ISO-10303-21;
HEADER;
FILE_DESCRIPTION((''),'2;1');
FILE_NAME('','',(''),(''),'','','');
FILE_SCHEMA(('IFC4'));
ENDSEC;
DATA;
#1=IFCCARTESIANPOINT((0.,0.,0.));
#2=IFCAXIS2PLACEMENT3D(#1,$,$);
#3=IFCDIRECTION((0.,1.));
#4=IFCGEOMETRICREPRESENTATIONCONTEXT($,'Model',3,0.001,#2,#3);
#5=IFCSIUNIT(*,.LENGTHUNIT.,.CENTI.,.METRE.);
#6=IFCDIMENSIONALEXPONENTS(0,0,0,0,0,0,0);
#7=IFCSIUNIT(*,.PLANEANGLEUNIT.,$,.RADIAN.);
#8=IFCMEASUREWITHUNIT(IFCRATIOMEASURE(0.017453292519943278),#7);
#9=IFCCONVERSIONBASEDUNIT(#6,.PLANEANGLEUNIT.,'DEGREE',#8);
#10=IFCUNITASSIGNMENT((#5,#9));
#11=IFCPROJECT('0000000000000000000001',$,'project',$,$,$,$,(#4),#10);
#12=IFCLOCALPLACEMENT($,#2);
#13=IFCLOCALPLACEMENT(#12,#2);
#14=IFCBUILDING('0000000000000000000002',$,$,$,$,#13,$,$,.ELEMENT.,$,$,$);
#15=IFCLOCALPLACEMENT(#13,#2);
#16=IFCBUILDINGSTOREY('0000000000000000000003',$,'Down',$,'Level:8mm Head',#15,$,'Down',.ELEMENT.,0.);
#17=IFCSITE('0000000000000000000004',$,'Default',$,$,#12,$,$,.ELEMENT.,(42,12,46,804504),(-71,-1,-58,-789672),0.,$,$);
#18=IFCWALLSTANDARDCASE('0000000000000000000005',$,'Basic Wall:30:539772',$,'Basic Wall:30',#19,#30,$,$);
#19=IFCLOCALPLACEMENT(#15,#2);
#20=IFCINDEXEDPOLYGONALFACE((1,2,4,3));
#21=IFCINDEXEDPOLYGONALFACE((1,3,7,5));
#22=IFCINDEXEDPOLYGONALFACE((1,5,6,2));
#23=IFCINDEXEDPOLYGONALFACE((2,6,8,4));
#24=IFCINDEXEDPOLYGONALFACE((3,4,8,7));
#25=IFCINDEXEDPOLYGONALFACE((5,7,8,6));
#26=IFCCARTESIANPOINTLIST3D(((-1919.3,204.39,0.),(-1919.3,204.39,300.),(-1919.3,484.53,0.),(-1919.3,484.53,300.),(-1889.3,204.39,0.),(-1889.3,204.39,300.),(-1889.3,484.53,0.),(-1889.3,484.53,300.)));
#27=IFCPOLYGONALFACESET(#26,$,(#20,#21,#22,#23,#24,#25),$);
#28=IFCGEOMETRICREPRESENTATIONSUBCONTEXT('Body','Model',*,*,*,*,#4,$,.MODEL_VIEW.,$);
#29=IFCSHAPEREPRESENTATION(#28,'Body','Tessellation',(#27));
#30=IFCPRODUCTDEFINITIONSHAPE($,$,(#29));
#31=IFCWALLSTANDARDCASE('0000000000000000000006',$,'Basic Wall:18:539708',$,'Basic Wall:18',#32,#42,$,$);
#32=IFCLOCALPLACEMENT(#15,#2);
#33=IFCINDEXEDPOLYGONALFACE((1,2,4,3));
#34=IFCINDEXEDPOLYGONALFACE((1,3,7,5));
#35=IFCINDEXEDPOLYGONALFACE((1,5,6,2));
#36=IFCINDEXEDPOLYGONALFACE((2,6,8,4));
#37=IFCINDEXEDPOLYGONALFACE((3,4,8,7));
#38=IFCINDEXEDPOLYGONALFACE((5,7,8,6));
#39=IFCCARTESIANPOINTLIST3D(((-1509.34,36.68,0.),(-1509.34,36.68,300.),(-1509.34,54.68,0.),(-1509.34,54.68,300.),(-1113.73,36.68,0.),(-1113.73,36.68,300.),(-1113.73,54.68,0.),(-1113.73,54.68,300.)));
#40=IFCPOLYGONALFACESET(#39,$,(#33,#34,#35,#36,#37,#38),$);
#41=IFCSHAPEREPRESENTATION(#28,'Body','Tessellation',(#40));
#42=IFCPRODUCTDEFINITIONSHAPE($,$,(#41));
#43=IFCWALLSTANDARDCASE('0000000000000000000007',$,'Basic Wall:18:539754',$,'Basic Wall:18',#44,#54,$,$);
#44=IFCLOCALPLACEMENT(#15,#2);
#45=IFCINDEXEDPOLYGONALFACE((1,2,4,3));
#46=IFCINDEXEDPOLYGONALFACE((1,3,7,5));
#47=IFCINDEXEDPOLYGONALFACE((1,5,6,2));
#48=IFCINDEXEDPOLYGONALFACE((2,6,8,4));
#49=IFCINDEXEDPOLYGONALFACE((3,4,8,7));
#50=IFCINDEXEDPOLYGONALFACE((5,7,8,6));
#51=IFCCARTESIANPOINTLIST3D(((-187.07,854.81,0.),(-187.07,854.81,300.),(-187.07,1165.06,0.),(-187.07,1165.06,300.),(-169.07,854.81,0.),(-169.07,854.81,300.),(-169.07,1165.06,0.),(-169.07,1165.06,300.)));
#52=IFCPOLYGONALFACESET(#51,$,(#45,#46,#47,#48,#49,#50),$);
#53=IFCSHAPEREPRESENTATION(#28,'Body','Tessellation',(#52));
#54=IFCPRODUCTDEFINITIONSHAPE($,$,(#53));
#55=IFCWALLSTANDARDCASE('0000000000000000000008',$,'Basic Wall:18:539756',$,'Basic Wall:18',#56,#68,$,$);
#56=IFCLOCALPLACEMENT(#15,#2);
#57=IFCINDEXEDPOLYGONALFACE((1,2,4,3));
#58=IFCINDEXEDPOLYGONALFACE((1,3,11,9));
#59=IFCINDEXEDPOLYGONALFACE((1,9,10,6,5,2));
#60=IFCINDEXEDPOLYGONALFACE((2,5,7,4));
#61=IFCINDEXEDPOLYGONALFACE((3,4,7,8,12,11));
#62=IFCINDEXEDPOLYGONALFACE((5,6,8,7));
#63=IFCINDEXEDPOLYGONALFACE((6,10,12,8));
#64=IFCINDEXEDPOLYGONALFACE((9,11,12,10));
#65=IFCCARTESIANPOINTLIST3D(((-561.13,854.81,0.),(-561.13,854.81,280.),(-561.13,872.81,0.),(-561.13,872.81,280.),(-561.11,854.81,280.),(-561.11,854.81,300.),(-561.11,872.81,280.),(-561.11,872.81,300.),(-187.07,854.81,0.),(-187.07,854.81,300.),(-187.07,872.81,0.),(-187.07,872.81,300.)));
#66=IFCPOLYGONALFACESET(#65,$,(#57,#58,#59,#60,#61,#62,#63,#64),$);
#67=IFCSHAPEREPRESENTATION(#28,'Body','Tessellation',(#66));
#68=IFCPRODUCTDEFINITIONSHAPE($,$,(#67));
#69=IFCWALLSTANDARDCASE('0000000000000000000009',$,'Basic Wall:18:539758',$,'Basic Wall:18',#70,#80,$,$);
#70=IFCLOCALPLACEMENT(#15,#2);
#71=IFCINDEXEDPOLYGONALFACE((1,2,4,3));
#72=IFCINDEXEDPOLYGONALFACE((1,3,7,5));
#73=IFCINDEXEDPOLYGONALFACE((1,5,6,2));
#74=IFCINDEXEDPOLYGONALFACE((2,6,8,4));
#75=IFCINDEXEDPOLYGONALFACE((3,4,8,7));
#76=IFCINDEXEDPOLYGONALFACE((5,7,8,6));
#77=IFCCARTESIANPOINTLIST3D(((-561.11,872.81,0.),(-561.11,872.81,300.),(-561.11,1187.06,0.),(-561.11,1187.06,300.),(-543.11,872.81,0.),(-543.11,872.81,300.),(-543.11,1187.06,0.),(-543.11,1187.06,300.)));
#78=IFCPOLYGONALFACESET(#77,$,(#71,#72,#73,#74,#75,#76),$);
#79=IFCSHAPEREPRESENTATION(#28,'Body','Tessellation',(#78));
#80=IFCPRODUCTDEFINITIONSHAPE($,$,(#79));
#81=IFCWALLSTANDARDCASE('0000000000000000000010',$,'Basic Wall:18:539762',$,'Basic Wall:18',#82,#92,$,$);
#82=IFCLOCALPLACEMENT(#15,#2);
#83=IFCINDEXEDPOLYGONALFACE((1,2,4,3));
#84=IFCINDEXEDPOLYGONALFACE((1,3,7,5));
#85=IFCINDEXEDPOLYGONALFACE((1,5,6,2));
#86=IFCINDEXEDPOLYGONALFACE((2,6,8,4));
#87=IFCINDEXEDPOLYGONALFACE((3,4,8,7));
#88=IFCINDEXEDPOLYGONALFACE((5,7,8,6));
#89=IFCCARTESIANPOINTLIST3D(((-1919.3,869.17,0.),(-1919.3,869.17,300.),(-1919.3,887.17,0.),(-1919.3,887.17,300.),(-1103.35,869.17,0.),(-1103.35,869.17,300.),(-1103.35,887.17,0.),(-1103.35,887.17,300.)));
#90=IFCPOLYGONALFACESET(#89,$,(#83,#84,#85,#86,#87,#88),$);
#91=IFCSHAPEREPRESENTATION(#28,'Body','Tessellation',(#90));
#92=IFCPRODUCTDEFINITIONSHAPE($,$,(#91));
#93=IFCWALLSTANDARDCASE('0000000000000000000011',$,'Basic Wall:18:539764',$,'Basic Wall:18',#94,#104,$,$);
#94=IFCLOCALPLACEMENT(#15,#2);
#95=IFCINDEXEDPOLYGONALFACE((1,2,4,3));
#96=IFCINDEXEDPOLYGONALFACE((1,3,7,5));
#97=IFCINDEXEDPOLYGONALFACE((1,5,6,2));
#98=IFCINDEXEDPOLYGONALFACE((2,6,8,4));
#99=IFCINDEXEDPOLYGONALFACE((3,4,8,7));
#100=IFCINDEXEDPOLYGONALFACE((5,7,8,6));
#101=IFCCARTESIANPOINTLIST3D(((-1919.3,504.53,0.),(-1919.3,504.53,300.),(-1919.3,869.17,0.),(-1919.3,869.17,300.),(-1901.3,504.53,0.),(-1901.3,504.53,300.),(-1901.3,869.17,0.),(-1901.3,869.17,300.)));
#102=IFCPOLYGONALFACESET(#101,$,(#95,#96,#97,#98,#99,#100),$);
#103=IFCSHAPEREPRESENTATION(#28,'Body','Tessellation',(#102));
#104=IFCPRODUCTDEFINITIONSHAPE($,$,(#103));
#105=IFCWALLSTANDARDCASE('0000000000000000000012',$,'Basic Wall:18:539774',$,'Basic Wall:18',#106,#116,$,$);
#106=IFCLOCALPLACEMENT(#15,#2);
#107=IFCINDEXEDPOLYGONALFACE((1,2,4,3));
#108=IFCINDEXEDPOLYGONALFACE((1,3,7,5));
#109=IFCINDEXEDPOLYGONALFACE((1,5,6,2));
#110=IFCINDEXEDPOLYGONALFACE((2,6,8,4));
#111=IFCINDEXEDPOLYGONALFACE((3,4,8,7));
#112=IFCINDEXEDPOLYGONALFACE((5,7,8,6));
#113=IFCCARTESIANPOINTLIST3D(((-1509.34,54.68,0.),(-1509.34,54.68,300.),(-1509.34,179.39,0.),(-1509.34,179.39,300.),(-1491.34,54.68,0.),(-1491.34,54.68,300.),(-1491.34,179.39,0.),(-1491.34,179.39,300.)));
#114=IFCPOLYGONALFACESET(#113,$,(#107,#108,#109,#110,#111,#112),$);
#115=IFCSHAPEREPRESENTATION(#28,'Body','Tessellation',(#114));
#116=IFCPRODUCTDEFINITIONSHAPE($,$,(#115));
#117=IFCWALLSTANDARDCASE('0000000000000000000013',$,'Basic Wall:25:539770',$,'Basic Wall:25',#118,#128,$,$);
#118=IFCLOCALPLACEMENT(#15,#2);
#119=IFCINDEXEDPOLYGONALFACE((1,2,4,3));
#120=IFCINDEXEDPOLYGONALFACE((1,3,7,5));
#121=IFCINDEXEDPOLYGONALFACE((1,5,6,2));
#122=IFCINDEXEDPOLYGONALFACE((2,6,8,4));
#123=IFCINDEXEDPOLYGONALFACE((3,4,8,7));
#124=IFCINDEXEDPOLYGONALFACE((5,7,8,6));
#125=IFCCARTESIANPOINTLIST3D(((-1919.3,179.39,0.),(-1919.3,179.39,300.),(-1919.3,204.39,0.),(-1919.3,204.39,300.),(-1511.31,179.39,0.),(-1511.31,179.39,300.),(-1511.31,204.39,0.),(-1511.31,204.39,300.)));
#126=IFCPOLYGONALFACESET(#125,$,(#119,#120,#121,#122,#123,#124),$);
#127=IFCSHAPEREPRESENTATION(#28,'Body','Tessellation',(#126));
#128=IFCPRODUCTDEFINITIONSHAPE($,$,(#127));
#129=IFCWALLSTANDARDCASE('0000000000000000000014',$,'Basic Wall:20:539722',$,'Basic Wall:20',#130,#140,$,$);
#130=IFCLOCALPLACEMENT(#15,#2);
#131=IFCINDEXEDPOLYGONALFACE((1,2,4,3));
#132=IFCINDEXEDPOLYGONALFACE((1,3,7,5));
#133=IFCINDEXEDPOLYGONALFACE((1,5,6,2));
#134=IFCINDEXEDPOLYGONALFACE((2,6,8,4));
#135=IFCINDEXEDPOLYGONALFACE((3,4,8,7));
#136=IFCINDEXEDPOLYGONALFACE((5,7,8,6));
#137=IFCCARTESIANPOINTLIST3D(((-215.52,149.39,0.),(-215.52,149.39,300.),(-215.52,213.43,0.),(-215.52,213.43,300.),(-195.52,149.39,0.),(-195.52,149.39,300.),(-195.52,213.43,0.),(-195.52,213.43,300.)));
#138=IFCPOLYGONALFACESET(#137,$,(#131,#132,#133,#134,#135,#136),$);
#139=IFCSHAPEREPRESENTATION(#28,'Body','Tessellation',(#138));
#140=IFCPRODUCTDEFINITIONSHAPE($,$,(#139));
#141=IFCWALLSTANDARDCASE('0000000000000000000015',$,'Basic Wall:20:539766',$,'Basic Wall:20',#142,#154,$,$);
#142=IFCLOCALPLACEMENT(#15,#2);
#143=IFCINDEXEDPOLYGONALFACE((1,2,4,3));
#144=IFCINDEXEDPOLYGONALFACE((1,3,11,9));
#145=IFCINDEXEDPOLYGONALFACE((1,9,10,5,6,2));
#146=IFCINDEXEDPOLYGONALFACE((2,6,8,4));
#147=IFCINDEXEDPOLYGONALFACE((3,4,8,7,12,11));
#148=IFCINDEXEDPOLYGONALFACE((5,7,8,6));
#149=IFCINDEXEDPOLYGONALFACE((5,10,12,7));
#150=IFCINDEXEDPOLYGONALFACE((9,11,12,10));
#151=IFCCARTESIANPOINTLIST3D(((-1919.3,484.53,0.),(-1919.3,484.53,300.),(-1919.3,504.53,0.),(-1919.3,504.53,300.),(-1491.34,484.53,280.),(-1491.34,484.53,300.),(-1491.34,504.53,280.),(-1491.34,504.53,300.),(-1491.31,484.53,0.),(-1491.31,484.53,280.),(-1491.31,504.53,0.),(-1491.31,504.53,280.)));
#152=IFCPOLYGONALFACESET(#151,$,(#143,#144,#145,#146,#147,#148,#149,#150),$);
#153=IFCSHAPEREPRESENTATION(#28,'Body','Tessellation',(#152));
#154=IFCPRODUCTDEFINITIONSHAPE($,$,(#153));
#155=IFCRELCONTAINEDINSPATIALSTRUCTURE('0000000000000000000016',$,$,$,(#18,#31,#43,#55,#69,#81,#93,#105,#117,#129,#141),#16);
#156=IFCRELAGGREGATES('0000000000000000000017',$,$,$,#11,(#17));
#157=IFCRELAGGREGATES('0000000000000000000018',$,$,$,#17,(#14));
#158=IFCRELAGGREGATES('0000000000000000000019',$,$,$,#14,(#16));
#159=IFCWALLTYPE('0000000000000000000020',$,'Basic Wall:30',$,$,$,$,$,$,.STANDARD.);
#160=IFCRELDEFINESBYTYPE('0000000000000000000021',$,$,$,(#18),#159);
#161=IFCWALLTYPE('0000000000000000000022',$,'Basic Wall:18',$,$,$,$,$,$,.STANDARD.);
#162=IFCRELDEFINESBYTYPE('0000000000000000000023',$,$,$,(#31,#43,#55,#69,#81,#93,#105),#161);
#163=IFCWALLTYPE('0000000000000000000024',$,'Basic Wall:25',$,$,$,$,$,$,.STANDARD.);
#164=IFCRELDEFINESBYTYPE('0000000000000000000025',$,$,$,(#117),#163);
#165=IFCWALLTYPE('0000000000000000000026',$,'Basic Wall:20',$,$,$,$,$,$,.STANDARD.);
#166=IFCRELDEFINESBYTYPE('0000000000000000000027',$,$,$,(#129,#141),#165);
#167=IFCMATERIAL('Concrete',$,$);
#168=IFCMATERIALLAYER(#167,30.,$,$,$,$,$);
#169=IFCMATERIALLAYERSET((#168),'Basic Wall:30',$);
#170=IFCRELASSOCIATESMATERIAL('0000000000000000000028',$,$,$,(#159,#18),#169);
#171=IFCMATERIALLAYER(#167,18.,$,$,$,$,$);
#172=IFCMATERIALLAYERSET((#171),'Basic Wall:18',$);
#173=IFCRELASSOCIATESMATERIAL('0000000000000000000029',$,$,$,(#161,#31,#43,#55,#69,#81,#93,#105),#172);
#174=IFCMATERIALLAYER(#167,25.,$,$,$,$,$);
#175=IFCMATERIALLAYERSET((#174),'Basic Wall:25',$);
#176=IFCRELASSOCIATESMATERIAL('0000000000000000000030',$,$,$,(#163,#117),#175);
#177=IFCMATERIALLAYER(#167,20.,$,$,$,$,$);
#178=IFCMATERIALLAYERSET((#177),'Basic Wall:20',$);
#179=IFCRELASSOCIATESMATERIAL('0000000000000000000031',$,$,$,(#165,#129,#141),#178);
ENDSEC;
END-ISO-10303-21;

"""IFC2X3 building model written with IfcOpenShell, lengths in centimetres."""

from ifc_helpers import new_model, entity, si_unit, converted_unit, direction, frame, frame_2d, origin, place, context, subcontext, project, spatial, polyline, rectangle, extrude, clip, bounded_halfspace, material, layer, layer_set, layer_usage, type_object, element, save


model = new_model("IFC2X3")

# Units and contexts
model_context = context("Model", 3, precision=0.001, world=origin(), true_north=direction((0.0, 1.0)))
body_context = subcontext(model_context, "Body", "Model", "MODEL_VIEW")
ifc_project = project(units=[si_unit("LENGTHUNIT", "METRE", prefix="CENTI"), converted_unit("PLANEANGLEUNIT", "DEGREE", entity("IfcRatioMeasure", 0.017453292519943278), si_unit("PLANEANGLEUNIT", "RADIAN"), dimensions=[0, 0, 0, 0, 0, 0, 0])], contexts=[model_context])

# Site, building, storey
site_placement = place(None, origin())
site = spatial("IfcSite", under=ifc_project, at=site_placement, Name="Default", CompositionType="ELEMENT", RefLatitude=(42, 12, 46, 804504), RefLongitude=(-71, -1, -58, -789672), RefElevation=0.0)
building_placement = place(site_placement, origin())
building = spatial("IfcBuilding", under=site, at=building_placement, CompositionType="ELEMENT")
storey_placement = place(building_placement, origin())
storey = spatial("IfcBuildingStorey", under=building, at=storey_placement, Name="Down", ObjectType="Level:8mm Head", LongName="Down", CompositionType="ELEMENT", Elevation=0.0)

# Walls
ifc_material = material(Name="Concrete")
ifc_layer_1 = layer(ifc_material, 30.0)
ifc_layer_set_1 = layer_set([ifc_layer_1], Name="Basic Wall:30")
ifc_layer_usage_1 = layer_usage(ifc_layer_set_1, "AXIS2", "POSITIVE", -15.0)
wall_type_1 = type_object("IfcWallType", Name="Basic Wall:30", PredefinedType="STANDARD", material=ifc_layer_set_1)
wall_1_placement = place(storey_placement, frame((-1904.3, 204.39, 0.0), z_axis=(0.0, 0.0, 1.0), x_axis=(0.0, 1.0, 0.0)))
element("IfcWallStandardCase", 1, at=wall_1_placement, inside=storey, type_object=wall_type_1, material=ifc_layer_usage_1, Name="Basic Wall:30:539772", ObjectType="Basic Wall:30", context=body_context, shape_type="SweptSolid", body=[
    extrude(rectangle(XDim=280.14, YDim=30.0, at=frame_2d((140.07, 0.0), x_axis=(-1.0, 0.0))), origin(), (0.0, 0.0, 1.0), 300.0),
])
ifc_layer_2 = layer(ifc_material, 18.0)
ifc_layer_set_2 = layer_set([ifc_layer_2], Name="Basic Wall:18")
ifc_layer_usage_2 = layer_usage(ifc_layer_set_2, "AXIS2", "POSITIVE", -9.0)
wall_type_2 = type_object("IfcWallType", Name="Basic Wall:18", PredefinedType="STANDARD", material=ifc_layer_set_2)
wall_2_placement = place(storey_placement, frame((-1113.73, 45.68, 0.0), z_axis=(0.0, 0.0, 1.0), x_axis=(-1.0, 0.0, 0.0)))
element("IfcWallStandardCase", 2, at=wall_2_placement, inside=storey, type_object=wall_type_2, material=ifc_layer_usage_2, Name="Basic Wall:18:539708", ObjectType="Basic Wall:18", context=body_context, shape_type="SweptSolid", body=[
    extrude(rectangle(XDim=395.6, YDim=18.0, at=frame_2d((197.8, 0.0), x_axis=(-1.0, 0.0))), origin(), (0.0, 0.0, 1.0), 300.0),
])
ifc_layer_usage_3 = layer_usage(ifc_layer_set_2, "AXIS2", "NEGATIVE", 9.0)
wall_3_placement = place(storey_placement, frame((-178.07, 1165.06, 0.0), z_axis=(0.0, 0.0, 1.0), x_axis=(0.0, -1.0, 0.0)))
element("IfcWallStandardCase", 3, at=wall_3_placement, inside=storey, type_object=wall_type_2, material=ifc_layer_usage_3, Name="Basic Wall:18:539754", ObjectType="Basic Wall:18", context=body_context, shape_type="SweptSolid", body=[
    extrude(rectangle(XDim=310.25, YDim=18.0, at=frame_2d((155.12, 0.0), x_axis=(-1.0, 0.0))), origin(), (0.0, 0.0, 1.0), 300.0),
])
ifc_layer_usage_4 = layer_usage(ifc_layer_set_2, "AXIS2", "POSITIVE", -9.0)
wall_4_placement = place(storey_placement, frame((-187.07, 863.81, 0.0), z_axis=(0.0, 0.0, 1.0), x_axis=(-1.0, 0.0, 0.0)))
element("IfcWallStandardCase", 4, at=wall_4_placement, inside=storey, type_object=wall_type_2, material=ifc_layer_usage_4, Name="Basic Wall:18:539756", ObjectType="Basic Wall:18", context=body_context, shape_type="Clipping", body=[
    clip(clip(extrude(rectangle(XDim=374.06, YDim=18.0, at=frame_2d((187.03, 0.0), x_axis=(-1.0, 0.0))), origin(), (0.0, 0.0, 1.0), 300.0), bounded_halfspace(frame((374.03, 9.0, 280.0), z_axis=(0.0, 0.0, -1.0), x_axis=(0.0, -1.0, 0.0)), True, frame((374.03, 9.0, 280.0), z_axis=(0.0, 0.0, -1.0), x_axis=(0.0, -1.0, 0.0)), polyline([(0.0, 0.0), (0.0, -0.03), (18.0, -0.03), (18.0, 0.0), (0.0, 0.0)]))), bounded_halfspace(frame((374.03, -9.0, 280.0), z_axis=(-1.0, 0.0, 0.0), x_axis=(0.0, 0.0, 1.0)), True, frame((374.03, -9.0, 280.0), z_axis=(-1.0, 0.0, 0.0), x_axis=(0.0, 0.0, 1.0)), polyline([(0.0, 0.0), (20.0, 0.0), (20.0, 18.0), (0.0, 18.0), (0.0, 0.0)]))),
])
ifc_layer_usage_5 = layer_usage(ifc_layer_set_2, "AXIS2", "POSITIVE", -9.0)
wall_5_placement = place(storey_placement, frame((-552.11, 1187.06, 0.0), z_axis=(0.0, 0.0, 1.0), x_axis=(0.0, -1.0, 0.0)))
element("IfcWallStandardCase", 5, at=wall_5_placement, inside=storey, type_object=wall_type_2, material=ifc_layer_usage_5, Name="Basic Wall:18:539758", ObjectType="Basic Wall:18", context=body_context, shape_type="SweptSolid", body=[
    extrude(rectangle(XDim=314.25, YDim=18.0, at=frame_2d((157.12, 0.0), x_axis=(-1.0, 0.0))), origin(), (0.0, 0.0, 1.0), 300.0),
])
ifc_layer_usage_6 = layer_usage(ifc_layer_set_2, "AXIS2", "POSITIVE", -9.0)
wall_6_placement = place(storey_placement, frame((-1103.35, 878.17, 0.0), z_axis=(0.0, 0.0, 1.0), x_axis=(-1.0, 0.0, 0.0)))
element("IfcWallStandardCase", 6, at=wall_6_placement, inside=storey, type_object=wall_type_2, material=ifc_layer_usage_6, Name="Basic Wall:18:539762", ObjectType="Basic Wall:18", context=body_context, shape_type="SweptSolid", body=[
    extrude(rectangle(XDim=815.95, YDim=18.0, at=frame_2d((407.98, 0.0), x_axis=(-1.0, 0.0))), origin(), (0.0, 0.0, 1.0), 300.0),
])
ifc_layer_usage_7 = layer_usage(ifc_layer_set_2, "AXIS2", "NEGATIVE", 9.0)
wall_7_placement = place(storey_placement, frame((-1910.3, 869.17, 0.0), z_axis=(0.0, 0.0, 1.0), x_axis=(0.0, -1.0, 0.0)))
element("IfcWallStandardCase", 7, at=wall_7_placement, inside=storey, type_object=wall_type_2, material=ifc_layer_usage_7, Name="Basic Wall:18:539764", ObjectType="Basic Wall:18", context=body_context, shape_type="SweptSolid", body=[
    extrude(rectangle(XDim=364.64, YDim=18.0, at=frame_2d((182.32, 0.0), x_axis=(-1.0, 0.0))), origin(), (0.0, 0.0, 1.0), 300.0),
])
ifc_layer_usage_8 = layer_usage(ifc_layer_set_2, "AXIS2", "NEGATIVE", 9.0)
wall_8_placement = place(storey_placement, frame((-1500.34, 179.39, 0.0), z_axis=(0.0, 0.0, 1.0), x_axis=(0.0, -1.0, 0.0)))
element("IfcWallStandardCase", 8, at=wall_8_placement, inside=storey, type_object=wall_type_2, material=ifc_layer_usage_8, Name="Basic Wall:18:539774", ObjectType="Basic Wall:18", context=body_context, shape_type="SweptSolid", body=[
    extrude(rectangle(XDim=124.71, YDim=18.0, at=frame_2d((62.36, 0.0), x_axis=(-1.0, 0.0))), origin(), (0.0, 0.0, 1.0), 300.0),
])
ifc_layer_3 = layer(ifc_material, 25.0)
ifc_layer_set_3 = layer_set([ifc_layer_3], Name="Basic Wall:25")
ifc_layer_usage_9 = layer_usage(ifc_layer_set_3, "AXIS2", "POSITIVE", -12.5)
wall_type_3 = type_object("IfcWallType", Name="Basic Wall:25", PredefinedType="STANDARD", material=ifc_layer_set_3)
wall_9_placement = place(storey_placement, frame((-1511.31, 191.89, 0.0), z_axis=(0.0, 0.0, 1.0), x_axis=(-1.0, 0.0, 0.0)))
element("IfcWallStandardCase", 9, at=wall_9_placement, inside=storey, type_object=wall_type_3, material=ifc_layer_usage_9, Name="Basic Wall:25:539770", ObjectType="Basic Wall:25", context=body_context, shape_type="SweptSolid", body=[
    extrude(rectangle(XDim=407.99, YDim=25.0, at=frame_2d((203.99, 0.0), x_axis=(-1.0, 0.0))), origin(), (0.0, 0.0, 1.0), 300.0),
])
ifc_layer_4 = layer(ifc_material, 20.0)
ifc_layer_set_4 = layer_set([ifc_layer_4], Name="Basic Wall:20")
ifc_layer_usage_10 = layer_usage(ifc_layer_set_4, "AXIS2", "POSITIVE", -10.0)
wall_type_4 = type_object("IfcWallType", Name="Basic Wall:20", PredefinedType="STANDARD", material=ifc_layer_set_4)
wall_10_placement = place(storey_placement, frame((-205.52, 213.43, 0.0), z_axis=(0.0, 0.0, 1.0), x_axis=(0.0, -1.0, 0.0)))
element("IfcWallStandardCase", 10, at=wall_10_placement, inside=storey, type_object=wall_type_4, material=ifc_layer_usage_10, Name="Basic Wall:20:539722", ObjectType="Basic Wall:20", context=body_context, shape_type="SweptSolid", body=[
    extrude(rectangle(XDim=64.04, YDim=20.0, at=frame_2d((32.02, 0.0), x_axis=(-1.0, 0.0))), origin(), (0.0, 0.0, 1.0), 300.0),
])
ifc_layer_usage_11 = layer_usage(ifc_layer_set_4, "AXIS2", "POSITIVE", -10.0)
wall_11_placement = place(storey_placement, frame((-1919.3, 494.53, 0.0)))
element("IfcWallStandardCase", 11, at=wall_11_placement, inside=storey, type_object=wall_type_4, material=ifc_layer_usage_11, Name="Basic Wall:20:539766", ObjectType="Basic Wall:20", context=body_context, shape_type="Clipping", body=[
    clip(clip(extrude(rectangle(XDim=427.99, YDim=20.0, at=frame_2d((213.99, 0.0), x_axis=(-1.0, 0.0))), origin(), (0.0, 0.0, 1.0), 300.0), bounded_halfspace(frame((427.96, 10.0, 280.0), z_axis=(0.0, 0.0, -1.0), x_axis=(0.0, 1.0, 0.0)), True, frame((427.96, 10.0, 280.0), z_axis=(0.0, 0.0, -1.0), x_axis=(0.0, 1.0, 0.0)), polyline([(0.0, 0.0), (0.0, 0.03), (-20.0, 0.03), (-20.0, 0.0), (0.0, 0.0)]))), bounded_halfspace(frame((427.96, -10.0, 280.0), z_axis=(-1.0, 0.0, 0.0), x_axis=(0.0, 0.0, 1.0)), True, frame((427.96, -10.0, 280.0), z_axis=(-1.0, 0.0, 0.0), x_axis=(0.0, 0.0, 1.0)), polyline([(0.0, 0.0), (20.0, 0.0), (20.0, 20.0), (0.0, 20.0), (0.0, 0.0)]))),
])

save(model, "model.ifc")
